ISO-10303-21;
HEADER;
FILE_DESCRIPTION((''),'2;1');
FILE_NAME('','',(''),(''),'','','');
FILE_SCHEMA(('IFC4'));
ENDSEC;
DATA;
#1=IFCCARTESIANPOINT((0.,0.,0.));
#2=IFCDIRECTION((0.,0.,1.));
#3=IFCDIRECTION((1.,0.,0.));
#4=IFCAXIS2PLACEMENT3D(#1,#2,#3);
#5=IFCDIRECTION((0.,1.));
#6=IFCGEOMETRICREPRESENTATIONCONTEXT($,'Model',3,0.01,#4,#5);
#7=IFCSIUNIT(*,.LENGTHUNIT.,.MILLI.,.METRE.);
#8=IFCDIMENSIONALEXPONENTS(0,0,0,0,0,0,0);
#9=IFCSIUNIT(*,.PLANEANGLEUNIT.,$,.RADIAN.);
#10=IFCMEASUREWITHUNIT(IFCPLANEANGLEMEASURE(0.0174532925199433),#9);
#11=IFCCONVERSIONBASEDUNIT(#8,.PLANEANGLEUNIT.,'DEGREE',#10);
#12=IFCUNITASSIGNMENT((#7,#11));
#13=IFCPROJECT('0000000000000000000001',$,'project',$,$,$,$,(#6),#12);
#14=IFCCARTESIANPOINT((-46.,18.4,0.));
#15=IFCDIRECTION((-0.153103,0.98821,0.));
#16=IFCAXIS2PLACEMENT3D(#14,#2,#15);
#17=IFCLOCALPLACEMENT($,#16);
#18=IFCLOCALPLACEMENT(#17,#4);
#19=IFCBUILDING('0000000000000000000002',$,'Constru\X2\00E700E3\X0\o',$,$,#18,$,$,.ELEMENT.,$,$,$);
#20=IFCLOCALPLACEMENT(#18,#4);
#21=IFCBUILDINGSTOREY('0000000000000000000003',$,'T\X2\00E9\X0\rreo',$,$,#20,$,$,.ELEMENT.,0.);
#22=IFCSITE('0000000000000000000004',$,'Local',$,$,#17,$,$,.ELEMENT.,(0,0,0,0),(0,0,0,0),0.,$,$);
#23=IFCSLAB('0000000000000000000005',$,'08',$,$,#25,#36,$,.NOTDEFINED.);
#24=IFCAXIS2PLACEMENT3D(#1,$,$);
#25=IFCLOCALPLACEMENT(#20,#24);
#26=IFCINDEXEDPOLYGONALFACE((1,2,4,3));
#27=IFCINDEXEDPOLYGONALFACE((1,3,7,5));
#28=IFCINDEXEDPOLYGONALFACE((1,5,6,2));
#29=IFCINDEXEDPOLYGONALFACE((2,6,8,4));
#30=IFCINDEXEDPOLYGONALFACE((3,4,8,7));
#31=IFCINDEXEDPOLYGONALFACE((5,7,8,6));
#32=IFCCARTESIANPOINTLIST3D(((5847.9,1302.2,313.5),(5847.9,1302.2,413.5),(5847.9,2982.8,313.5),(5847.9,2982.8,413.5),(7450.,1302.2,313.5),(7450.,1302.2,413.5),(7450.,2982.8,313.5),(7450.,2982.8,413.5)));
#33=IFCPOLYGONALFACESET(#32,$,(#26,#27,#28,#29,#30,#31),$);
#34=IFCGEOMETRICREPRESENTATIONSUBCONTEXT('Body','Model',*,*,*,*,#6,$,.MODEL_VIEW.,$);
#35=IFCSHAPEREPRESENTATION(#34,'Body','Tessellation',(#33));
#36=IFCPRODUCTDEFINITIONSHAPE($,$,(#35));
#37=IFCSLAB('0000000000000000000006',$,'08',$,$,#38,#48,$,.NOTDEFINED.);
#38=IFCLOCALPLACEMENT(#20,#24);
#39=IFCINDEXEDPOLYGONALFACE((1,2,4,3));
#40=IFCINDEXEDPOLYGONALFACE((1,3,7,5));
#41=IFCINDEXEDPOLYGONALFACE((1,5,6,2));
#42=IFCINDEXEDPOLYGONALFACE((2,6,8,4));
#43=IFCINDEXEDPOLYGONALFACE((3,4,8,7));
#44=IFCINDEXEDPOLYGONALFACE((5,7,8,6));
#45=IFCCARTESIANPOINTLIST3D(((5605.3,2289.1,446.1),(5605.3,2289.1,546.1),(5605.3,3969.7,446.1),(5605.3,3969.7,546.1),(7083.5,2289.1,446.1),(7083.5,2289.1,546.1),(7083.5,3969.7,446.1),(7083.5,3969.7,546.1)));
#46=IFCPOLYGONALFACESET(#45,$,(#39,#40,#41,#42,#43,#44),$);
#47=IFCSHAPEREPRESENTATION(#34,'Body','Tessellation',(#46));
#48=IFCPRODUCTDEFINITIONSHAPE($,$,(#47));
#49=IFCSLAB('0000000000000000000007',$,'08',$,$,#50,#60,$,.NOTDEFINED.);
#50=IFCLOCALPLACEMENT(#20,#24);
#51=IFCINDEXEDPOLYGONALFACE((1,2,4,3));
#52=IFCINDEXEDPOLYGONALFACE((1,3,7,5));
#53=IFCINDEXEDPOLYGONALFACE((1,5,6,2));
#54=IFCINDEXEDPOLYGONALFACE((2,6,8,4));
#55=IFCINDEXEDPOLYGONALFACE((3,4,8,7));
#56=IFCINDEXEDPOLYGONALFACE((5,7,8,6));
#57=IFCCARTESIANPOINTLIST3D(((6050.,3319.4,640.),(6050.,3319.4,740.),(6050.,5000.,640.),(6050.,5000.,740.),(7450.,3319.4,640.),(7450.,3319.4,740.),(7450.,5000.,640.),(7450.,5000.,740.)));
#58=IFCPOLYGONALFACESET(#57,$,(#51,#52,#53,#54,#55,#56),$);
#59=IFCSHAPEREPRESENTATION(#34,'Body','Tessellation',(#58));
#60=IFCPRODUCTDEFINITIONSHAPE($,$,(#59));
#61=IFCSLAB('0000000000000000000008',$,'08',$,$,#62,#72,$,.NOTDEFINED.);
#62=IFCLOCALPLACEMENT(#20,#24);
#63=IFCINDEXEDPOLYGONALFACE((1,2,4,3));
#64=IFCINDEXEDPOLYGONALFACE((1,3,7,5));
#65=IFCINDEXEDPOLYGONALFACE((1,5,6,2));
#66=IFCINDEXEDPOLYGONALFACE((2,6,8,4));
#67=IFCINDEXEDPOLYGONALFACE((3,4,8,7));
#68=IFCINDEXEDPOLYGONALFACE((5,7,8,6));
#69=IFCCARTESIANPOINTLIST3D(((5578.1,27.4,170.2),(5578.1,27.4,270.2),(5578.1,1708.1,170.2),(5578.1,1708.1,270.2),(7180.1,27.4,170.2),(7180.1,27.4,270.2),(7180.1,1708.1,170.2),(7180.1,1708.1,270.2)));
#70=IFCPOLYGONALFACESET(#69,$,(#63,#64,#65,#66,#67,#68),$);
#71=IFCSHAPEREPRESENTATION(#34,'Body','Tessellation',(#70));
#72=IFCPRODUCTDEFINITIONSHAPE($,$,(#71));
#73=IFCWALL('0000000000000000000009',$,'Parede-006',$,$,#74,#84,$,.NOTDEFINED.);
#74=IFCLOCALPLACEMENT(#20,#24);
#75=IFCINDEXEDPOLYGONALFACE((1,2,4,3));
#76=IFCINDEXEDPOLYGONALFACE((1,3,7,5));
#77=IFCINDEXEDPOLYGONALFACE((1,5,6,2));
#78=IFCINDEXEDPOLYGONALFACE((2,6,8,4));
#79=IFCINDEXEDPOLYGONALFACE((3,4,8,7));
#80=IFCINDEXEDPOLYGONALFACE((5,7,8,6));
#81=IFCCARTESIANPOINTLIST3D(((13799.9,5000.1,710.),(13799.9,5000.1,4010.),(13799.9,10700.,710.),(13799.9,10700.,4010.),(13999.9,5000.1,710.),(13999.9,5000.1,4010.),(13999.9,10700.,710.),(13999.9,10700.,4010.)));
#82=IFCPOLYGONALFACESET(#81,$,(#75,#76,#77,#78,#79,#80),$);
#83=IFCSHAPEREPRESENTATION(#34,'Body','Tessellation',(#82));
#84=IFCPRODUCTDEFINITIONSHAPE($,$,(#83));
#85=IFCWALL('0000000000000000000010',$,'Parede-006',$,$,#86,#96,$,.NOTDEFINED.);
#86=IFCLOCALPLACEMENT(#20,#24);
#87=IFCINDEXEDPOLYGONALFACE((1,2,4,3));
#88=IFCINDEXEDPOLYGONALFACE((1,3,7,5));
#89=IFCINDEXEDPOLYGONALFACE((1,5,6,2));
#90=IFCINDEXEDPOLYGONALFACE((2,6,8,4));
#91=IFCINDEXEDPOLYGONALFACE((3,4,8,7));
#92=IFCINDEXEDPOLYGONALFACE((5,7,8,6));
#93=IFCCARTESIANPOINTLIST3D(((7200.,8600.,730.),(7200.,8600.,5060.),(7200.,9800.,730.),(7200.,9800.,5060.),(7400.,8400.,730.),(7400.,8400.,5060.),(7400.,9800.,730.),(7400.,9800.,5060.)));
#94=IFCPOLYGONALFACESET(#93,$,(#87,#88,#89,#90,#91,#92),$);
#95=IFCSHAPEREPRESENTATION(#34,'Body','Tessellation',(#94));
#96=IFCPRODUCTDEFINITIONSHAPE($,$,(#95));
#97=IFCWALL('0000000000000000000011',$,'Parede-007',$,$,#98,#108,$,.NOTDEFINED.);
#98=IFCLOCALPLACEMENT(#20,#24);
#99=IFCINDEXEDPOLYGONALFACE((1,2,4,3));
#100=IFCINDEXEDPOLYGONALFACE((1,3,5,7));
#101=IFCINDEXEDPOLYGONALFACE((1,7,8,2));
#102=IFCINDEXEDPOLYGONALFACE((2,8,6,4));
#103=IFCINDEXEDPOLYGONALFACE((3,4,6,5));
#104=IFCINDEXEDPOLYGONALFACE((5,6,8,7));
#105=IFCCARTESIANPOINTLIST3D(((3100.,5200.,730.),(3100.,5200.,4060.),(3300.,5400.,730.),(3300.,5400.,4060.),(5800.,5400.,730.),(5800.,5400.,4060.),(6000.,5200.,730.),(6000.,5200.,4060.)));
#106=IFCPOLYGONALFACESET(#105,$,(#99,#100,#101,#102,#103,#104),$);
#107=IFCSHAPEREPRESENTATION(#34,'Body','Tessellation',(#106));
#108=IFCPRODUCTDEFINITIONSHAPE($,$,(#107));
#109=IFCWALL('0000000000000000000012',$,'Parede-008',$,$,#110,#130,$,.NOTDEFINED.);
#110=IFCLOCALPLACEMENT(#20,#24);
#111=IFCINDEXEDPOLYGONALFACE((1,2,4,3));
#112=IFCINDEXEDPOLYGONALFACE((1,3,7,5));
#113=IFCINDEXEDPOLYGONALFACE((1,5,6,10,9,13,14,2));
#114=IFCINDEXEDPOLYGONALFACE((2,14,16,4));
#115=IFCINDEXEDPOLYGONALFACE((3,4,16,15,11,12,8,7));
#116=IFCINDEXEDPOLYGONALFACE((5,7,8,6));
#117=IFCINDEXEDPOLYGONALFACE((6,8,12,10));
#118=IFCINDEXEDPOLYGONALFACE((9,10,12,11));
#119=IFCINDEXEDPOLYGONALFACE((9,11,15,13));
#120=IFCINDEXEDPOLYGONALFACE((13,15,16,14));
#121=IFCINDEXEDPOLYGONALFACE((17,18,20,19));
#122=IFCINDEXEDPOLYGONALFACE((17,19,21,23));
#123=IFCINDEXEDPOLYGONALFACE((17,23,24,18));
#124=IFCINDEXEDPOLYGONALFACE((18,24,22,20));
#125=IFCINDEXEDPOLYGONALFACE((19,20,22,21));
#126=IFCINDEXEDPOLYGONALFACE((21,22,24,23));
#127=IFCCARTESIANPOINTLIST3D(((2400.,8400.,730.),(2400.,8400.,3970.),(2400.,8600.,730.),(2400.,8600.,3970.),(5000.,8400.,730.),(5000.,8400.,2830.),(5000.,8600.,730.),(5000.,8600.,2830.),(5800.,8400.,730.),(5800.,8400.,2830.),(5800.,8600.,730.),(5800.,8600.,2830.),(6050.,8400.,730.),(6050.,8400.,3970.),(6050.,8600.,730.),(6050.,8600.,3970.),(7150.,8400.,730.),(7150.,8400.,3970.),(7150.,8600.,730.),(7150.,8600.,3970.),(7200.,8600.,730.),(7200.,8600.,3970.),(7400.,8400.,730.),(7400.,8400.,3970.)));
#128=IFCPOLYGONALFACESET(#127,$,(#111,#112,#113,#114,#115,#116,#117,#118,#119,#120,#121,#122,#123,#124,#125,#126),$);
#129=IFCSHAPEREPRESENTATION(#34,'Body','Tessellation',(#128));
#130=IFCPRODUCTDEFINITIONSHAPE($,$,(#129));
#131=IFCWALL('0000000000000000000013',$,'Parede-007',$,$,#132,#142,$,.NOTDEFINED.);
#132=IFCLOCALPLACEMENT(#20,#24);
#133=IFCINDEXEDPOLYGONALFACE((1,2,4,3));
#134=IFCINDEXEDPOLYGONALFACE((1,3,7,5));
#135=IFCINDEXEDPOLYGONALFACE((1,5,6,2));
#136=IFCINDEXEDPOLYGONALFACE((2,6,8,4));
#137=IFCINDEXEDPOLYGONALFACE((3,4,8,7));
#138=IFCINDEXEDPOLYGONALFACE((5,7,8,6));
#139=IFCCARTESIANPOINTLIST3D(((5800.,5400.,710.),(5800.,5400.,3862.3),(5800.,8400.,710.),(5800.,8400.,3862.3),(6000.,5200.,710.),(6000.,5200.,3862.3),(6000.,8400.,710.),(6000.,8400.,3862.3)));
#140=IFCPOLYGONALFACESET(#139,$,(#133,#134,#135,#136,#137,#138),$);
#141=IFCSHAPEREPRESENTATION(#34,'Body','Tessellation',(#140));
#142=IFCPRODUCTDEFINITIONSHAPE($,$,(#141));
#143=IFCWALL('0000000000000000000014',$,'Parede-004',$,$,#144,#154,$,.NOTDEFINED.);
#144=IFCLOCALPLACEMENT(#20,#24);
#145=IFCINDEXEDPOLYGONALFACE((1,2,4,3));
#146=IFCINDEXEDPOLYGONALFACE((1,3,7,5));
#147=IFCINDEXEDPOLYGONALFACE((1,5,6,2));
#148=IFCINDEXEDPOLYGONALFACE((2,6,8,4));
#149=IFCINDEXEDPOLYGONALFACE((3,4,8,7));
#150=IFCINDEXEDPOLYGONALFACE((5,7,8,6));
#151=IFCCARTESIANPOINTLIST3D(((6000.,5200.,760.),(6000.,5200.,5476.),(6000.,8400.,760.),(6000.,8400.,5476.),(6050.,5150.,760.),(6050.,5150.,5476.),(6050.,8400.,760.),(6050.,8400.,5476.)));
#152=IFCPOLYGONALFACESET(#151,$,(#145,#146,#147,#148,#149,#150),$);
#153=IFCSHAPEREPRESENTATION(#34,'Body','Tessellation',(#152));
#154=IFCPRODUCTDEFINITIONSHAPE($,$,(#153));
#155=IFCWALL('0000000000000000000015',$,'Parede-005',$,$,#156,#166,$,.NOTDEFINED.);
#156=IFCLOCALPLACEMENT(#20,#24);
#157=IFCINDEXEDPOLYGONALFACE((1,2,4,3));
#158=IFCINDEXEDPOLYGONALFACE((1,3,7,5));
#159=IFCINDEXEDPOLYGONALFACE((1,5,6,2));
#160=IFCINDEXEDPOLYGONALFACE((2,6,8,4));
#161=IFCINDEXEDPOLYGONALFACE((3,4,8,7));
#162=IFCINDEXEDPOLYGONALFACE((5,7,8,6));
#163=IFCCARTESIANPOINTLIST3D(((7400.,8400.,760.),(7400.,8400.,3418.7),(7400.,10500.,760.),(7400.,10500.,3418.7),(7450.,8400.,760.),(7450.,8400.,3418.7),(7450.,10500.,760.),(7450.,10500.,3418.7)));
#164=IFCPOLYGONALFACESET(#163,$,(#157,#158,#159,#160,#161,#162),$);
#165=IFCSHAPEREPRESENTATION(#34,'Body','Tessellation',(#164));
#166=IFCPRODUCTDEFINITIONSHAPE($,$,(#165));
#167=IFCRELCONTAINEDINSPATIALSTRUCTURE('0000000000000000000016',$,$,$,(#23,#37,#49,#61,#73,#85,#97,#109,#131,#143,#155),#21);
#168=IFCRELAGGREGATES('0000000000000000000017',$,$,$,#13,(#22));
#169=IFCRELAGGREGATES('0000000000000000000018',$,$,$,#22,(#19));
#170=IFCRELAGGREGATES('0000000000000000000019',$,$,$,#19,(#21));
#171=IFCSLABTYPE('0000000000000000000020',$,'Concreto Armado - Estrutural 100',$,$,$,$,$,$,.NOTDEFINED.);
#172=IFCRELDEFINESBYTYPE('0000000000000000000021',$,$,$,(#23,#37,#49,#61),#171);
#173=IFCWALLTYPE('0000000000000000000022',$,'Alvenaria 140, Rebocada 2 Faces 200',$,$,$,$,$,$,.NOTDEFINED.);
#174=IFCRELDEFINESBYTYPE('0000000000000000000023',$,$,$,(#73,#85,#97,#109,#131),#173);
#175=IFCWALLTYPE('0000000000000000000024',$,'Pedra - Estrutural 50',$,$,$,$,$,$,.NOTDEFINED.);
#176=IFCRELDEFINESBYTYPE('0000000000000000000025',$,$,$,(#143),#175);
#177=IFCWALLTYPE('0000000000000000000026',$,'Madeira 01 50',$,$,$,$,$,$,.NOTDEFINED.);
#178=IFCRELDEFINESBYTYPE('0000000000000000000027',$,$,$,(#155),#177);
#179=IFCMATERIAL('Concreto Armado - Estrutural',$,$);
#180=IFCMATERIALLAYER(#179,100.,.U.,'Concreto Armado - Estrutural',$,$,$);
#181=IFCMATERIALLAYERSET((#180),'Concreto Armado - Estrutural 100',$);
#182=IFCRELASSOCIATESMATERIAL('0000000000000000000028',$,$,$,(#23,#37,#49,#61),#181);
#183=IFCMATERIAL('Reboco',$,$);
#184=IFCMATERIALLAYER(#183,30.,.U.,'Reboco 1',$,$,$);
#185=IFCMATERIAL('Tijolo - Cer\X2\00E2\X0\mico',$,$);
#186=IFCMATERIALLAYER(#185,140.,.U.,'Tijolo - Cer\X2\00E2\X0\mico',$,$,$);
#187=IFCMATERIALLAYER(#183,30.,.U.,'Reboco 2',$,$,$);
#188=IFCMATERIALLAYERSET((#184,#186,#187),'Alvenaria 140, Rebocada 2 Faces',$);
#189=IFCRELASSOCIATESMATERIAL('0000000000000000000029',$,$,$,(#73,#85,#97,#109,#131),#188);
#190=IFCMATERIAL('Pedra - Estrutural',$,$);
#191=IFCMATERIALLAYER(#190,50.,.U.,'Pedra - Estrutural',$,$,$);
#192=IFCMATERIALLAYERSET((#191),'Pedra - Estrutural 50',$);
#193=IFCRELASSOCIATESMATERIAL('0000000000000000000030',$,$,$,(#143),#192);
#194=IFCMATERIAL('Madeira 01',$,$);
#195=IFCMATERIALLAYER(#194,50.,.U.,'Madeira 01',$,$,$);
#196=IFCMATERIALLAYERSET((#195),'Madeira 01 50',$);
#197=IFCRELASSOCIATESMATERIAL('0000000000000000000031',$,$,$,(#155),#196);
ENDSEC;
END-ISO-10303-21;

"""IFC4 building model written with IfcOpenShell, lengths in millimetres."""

from ifc_helpers import new_model, entity, si_unit, converted_unit, direction, frame, origin_with_axes, origin_2d_with_axis, place, context, subcontext, project, spatial, line, indexed_curve, rectangle, outline, extrude, material, layer, layer_set, layer_usage, type_object, element, save


model = new_model("IFC4")

# Units and contexts
model_context = context("Model", 3, precision=0.01, world=origin_with_axes(), true_north=direction((0.0, 1.0)))
body_context = subcontext(model_context, "Body", "Model", "MODEL_VIEW")
ifc_project = project(units=[si_unit("LENGTHUNIT", "METRE", prefix="MILLI"), converted_unit("PLANEANGLEUNIT", "DEGREE", entity("IfcPlaneAngleMeasure", 0.0174532925199433), si_unit("PLANEANGLEUNIT", "RADIAN"), dimensions=[0, 0, 0, 0, 0, 0, 0])], contexts=[model_context])

# Site, building, storey
site_placement = place(None, frame((-46.0, 18.4, 0.0), z_axis=(0.0, 0.0, 1.0), x_axis=(-0.153103, 0.98821, 0.0)))
site = spatial("IfcSite", under=ifc_project, at=site_placement, Name="Local", CompositionType="ELEMENT", RefLatitude=(0, 0, 0, 0), RefLongitude=(0, 0, 0, 0), RefElevation=0.0)
building_placement = place(site_placement, origin_with_axes())
building = spatial("IfcBuilding", under=site, at=building_placement, Name="Construção", CompositionType="ELEMENT")
storey_placement = place(building_placement, origin_with_axes())
storey = spatial("IfcBuildingStorey", under=building, at=storey_placement, Name="Térreo", CompositionType="ELEMENT", Elevation=0.0)

# Slabs
ifc_material_1 = material(Name="Concreto Armado - Estrutural")
ifc_layer_1 = layer(ifc_material_1, 100.0, ventilated="UNKNOWN", Name="Concreto Armado - Estrutural")
ifc_layer_set_1 = layer_set([ifc_layer_1], Name="Concreto Armado - Estrutural 100")
ifc_layer_usage_1 = layer_usage(ifc_layer_set_1, "AXIS3", "NEGATIVE", 100.0)
slab_type = type_object("IfcSlabType", Name="Concreto Armado - Estrutural 100", PredefinedType="NOTDEFINED")
slab_1_placement = place(storey_placement, frame((5847.9, 1302.2, 413.5), z_axis=(0.0, 0.0, 1.0), x_axis=(1.0, 0.0, 0.0)))
element("IfcSlab", 1, at=slab_1_placement, inside=storey, type_object=slab_type, material=ifc_layer_usage_1, Name="08", PredefinedType="NOTDEFINED", context=body_context, shape_type="SweptSolid", body=[
    extrude(outline(indexed_curve([(0.0, 0.0), (1602.1, 0.0), (1602.1, 1680.7), (0.0, 1680.7)], segments=[line(1, 2, 3, 4, 1)])), frame((0.0, 0.0, -100.0), z_axis=(0.0, 0.0, 1.0), x_axis=(1.0, 0.0, 0.0)), (0.0, 0.0, 1.0), 100.0),
])
ifc_layer_usage_2 = layer_usage(ifc_layer_set_1, "AXIS3", "NEGATIVE", 100.0)
slab_2_placement = place(storey_placement, frame((5605.3, 2289.1, 546.1), z_axis=(0.0, 0.0, 1.0), x_axis=(1.0, 0.0, 0.0)))
element("IfcSlab", 2, at=slab_2_placement, inside=storey, type_object=slab_type, material=ifc_layer_usage_2, Name="08", PredefinedType="NOTDEFINED", context=body_context, shape_type="SweptSolid", body=[
    extrude(outline(indexed_curve([(0.0, 0.0), (1478.2, 0.0), (1478.2, 1680.7), (0.0, 1680.7)], segments=[line(1, 2, 3, 4, 1)])), frame((0.0, 0.0, -100.0), z_axis=(0.0, 0.0, 1.0), x_axis=(1.0, 0.0, 0.0)), (0.0, 0.0, 1.0), 100.0),
])
ifc_layer_usage_3 = layer_usage(ifc_layer_set_1, "AXIS3", "NEGATIVE", 100.0)
slab_3_placement = place(storey_placement, frame((6050.0, 3319.4, 740.0), z_axis=(0.0, 0.0, 1.0), x_axis=(1.0, 0.0, 0.0)))
element("IfcSlab", 3, at=slab_3_placement, inside=storey, type_object=slab_type, material=ifc_layer_usage_3, Name="08", PredefinedType="NOTDEFINED", context=body_context, shape_type="SweptSolid", body=[
    extrude(outline(indexed_curve([(0.0, 0.0), (1400.0, 0.0), (1400.0, 1680.7), (0.0, 1680.7)], segments=[line(1, 2, 3, 4, 1)])), frame((0.0, 0.0, -100.0), z_axis=(0.0, 0.0, 1.0), x_axis=(1.0, 0.0, 0.0)), (0.0, 0.0, 1.0), 100.0),
])
ifc_layer_usage_4 = layer_usage(ifc_layer_set_1, "AXIS3", "NEGATIVE", 100.0)
slab_4_placement = place(storey_placement, frame((5578.1, 27.4, 270.2), z_axis=(0.0, 0.0, 1.0), x_axis=(1.0, 0.0, 0.0)))
element("IfcSlab", 4, at=slab_4_placement, inside=storey, type_object=slab_type, material=ifc_layer_usage_4, Name="08", PredefinedType="NOTDEFINED", context=body_context, shape_type="SweptSolid", body=[
    extrude(outline(indexed_curve([(0.0, 0.0), (1602.1, 0.0), (1602.1, 1680.7), (0.0, 1680.7)], segments=[line(1, 2, 3, 4, 1)])), frame((0.0, 0.0, -100.0), z_axis=(0.0, 0.0, 1.0), x_axis=(1.0, 0.0, 0.0)), (0.0, 0.0, 1.0), 100.0),
])

# Walls
ifc_material_2 = material(Name="Reboco")
ifc_layer_2 = layer(ifc_material_2, 30.0, ventilated="UNKNOWN", Name="Reboco 1")
ifc_material_3 = material(Name="Tijolo - Cerâmico")
ifc_layer_3 = layer(ifc_material_3, 140.0, ventilated="UNKNOWN", Name="Tijolo - Cerâmico")
ifc_layer_4 = layer(ifc_material_2, 30.0, ventilated="UNKNOWN", Name="Reboco 2")
ifc_layer_set_2 = layer_set([ifc_layer_2, ifc_layer_3, ifc_layer_4], Name="Alvenaria 140, Rebocada 2 Faces")
ifc_layer_usage_5 = layer_usage(ifc_layer_set_2, "AXIS2", "NEGATIVE", 0.0)
wall_type_1 = type_object("IfcWallType", Name="Alvenaria 140, Rebocada 2 Faces 200", PredefinedType="NOTDEFINED")
wall_1_placement = place(storey_placement, frame((13799.9, 5000.1, 710.0), z_axis=(0.0, 0.0, 1.0), x_axis=(-0.000002, 1.0, 0.0)))
element("IfcWall", 5, at=wall_1_placement, inside=storey, type_object=wall_type_1, material=ifc_layer_usage_5, Name="Parede-006", PredefinedType="NOTDEFINED", context=body_context, shape_type="SweptSolid", body=[
    extrude(outline(indexed_curve([(0.0, -200.0), (5700.0, -200.0), (5700.0, 0.0), (0.0, 0.0)], segments=[line(1, 2, 3, 4, 1)])), origin_with_axes(), (0.0, 0.0, 1.0), 3300.0),
])
ifc_layer_usage_6 = layer_usage(ifc_layer_set_2, "AXIS2", "POSITIVE", 0.0)
wall_2_placement = place(storey_placement, frame((7400.0, 8600.0, 730.0), z_axis=(0.0, 0.0, 1.0), x_axis=(0.0, 1.0, 0.0)))
element("IfcWall", 6, at=wall_2_placement, inside=storey, type_object=wall_type_1, material=ifc_layer_usage_6, Name="Parede-006", PredefinedType="NOTDEFINED", context=body_context, shape_type="SweptSolid", body=[
    extrude(outline(indexed_curve([(-200.0, 0.0), (1200.0, 0.0), (1200.0, 200.0), (0.0, 200.0)], segments=[line(1, 2, 3, 4, 1)])), origin_with_axes(), (0.0, 0.0, 1.0), 4330.0),
])
ifc_layer_usage_7 = layer_usage(ifc_layer_set_2, "AXIS2", "NEGATIVE", 0.0)
wall_3_placement = place(storey_placement, frame((6000.0, 5200.0, 730.0), z_axis=(0.0, 0.0, 1.0), x_axis=(-1.0, -0.000002, 0.0)))
element("IfcWall", 7, at=wall_3_placement, inside=storey, type_object=wall_type_1, material=ifc_layer_usage_7, Name="Parede-007", PredefinedType="NOTDEFINED", context=body_context, shape_type="SweptSolid", body=[
    extrude(outline(indexed_curve([(200.0, -200.0), (2700.0, -200.0), (2900.0, 0.0), (0.0, 0.0)], segments=[line(1, 2, 3, 4, 1)])), origin_with_axes(), (0.0, 0.0, 1.0), 3330.0),
])

# Wall, openings
ifc_layer_usage_8 = layer_usage(ifc_layer_set_2, "AXIS2", "POSITIVE", 0.0)
wall_4_placement = place(storey_placement, frame((7400.0, 8600.0, 730.0), z_axis=(0.0, 0.0, 1.0), x_axis=(-1.0, 0.0, 0.0)))
wall_4 = element("IfcWall", 8, at=wall_4_placement, inside=storey, type_object=wall_type_1, material=ifc_layer_usage_8, Name="Parede-008", PredefinedType="NOTDEFINED", context=body_context, shape_type="SweptSolid", body=[
    extrude(outline(indexed_curve([(200.0, 0.0), (5000.0, 0.0), (5000.0, 200.0), (0.0, 200.0)], segments=[line(1, 2, 3, 4, 1)])), origin_with_axes(), (0.0, 0.0, 1.0), 3240.0),
])
opening_1_placement = place(wall_4_placement, frame((2000.0, 0.0, 0.0), z_axis=(0.0, 0.0, 1.0), x_axis=(1.0, 0.0, 0.0)))
element("IfcOpeningElement", 9, at=opening_1_placement, cuts=wall_4, context=body_context, shape_type="SweptSolid", body=[
    extrude(rectangle(XDim=800.0, YDim=2100.0, at=origin_2d_with_axis()), frame((0.0, 200.0, 1050.0), z_axis=(0.0, 1.0, 0.0), x_axis=(-1.0, 0.0, 0.0)), (0.0, 0.0, -1.0), 600.0),
])
opening_2_placement = place(wall_4_placement, frame((800.0, 0.0, 0.0), z_axis=(0.0, 0.0, 1.0), x_axis=(1.0, 0.0, 0.0)))
element("IfcOpeningElement", 10, at=opening_2_placement, cuts=wall_4, context=body_context, shape_type="SweptSolid", body=[
    extrude(rectangle(XDim=1100.0, YDim=3500.0, at=origin_2d_with_axis()), frame((0.0, -200.0, 1750.0), z_axis=(0.0, 1.0, 0.0), x_axis=(-1.0, 0.0, 0.0)), (0.0, 0.0, 1.0), 600.0),
])

# Walls
ifc_layer_usage_9 = layer_usage(ifc_layer_set_2, "AXIS2", "POSITIVE", 0.0)
wall_5_placement = place(storey_placement, frame((6000.0, 5200.0, 710.0), z_axis=(0.0, 0.0, 1.0), x_axis=(-0.000004, 1.0, 0.0)))
element("IfcWall", 11, at=wall_5_placement, inside=storey, type_object=wall_type_1, material=ifc_layer_usage_9, Name="Parede-007", PredefinedType="NOTDEFINED", context=body_context, shape_type="SweptSolid", body=[
    extrude(outline(indexed_curve([(0.0, 0.0), (3200.0, 0.0), (3200.0, 200.0), (200.0, 200.0)], segments=[line(1, 2, 3, 4, 1)])), origin_with_axes(), (0.0, 0.0, 1.0), 3152.3),
])
ifc_material_4 = material(Name="Pedra - Estrutural")
ifc_layer_5 = layer(ifc_material_4, 50.0, ventilated="UNKNOWN", Name="Pedra - Estrutural")
ifc_layer_set_3 = layer_set([ifc_layer_5], Name="Pedra - Estrutural 50")
ifc_layer_usage_10 = layer_usage(ifc_layer_set_3, "AXIS2", "POSITIVE", 0.0)
wall_type_2 = type_object("IfcWallType", Name="Pedra - Estrutural 50", PredefinedType="NOTDEFINED")
wall_6_placement = place(storey_placement, frame((6000.0, 8400.0, 760.0), z_axis=(0.0, 0.0, 1.0), x_axis=(0.000003, -1.0, 0.0)))
element("IfcWall", 12, at=wall_6_placement, inside=storey, type_object=wall_type_2, material=ifc_layer_usage_10, Name="Parede-004", PredefinedType="NOTDEFINED", context=body_context, shape_type="SweptSolid", body=[
    extrude(outline(indexed_curve([(0.0, 0.0), (3200.0, 0.0), (3250.0, 50.0), (0.0, 50.0)], segments=[line(1, 2, 3, 4, 1)])), origin_with_axes(), (0.0, 0.0, 1.0), 4716.0),
])
ifc_material_5 = material(Name="Madeira 01")
ifc_layer_6 = layer(ifc_material_5, 50.0, ventilated="UNKNOWN", Name="Madeira 01")
ifc_layer_set_4 = layer_set([ifc_layer_6], Name="Madeira 01 50")
wall_type_3 = type_object("IfcWallType", Name="Madeira 01 50", PredefinedType="NOTDEFINED")
ifc_layer_usage_11 = layer_usage(ifc_layer_set_4, "AXIS2", "NEGATIVE", 50.0)
wall_7_placement = place(storey_placement, frame((7450.0, 8400.0, 760.0), z_axis=(0.0, 0.0, 1.0), x_axis=(0.0, 1.0, 0.0)))
element("IfcWall", 13, at=wall_7_placement, inside=storey, type_object=wall_type_3, material=ifc_layer_usage_11, Name="Parede-005", PredefinedType="NOTDEFINED", context=body_context, shape_type="SweptSolid", body=[
    extrude(outline(indexed_curve([(0.0, 0.0), (2100.0, 0.0), (2100.0, 50.0), (0.0, 50.0)], segments=[line(1, 2, 3, 4, 1)])), origin_with_axes(), (0.0, 0.0, 1.0), 2658.7),
])

save(model, "model.ifc")
